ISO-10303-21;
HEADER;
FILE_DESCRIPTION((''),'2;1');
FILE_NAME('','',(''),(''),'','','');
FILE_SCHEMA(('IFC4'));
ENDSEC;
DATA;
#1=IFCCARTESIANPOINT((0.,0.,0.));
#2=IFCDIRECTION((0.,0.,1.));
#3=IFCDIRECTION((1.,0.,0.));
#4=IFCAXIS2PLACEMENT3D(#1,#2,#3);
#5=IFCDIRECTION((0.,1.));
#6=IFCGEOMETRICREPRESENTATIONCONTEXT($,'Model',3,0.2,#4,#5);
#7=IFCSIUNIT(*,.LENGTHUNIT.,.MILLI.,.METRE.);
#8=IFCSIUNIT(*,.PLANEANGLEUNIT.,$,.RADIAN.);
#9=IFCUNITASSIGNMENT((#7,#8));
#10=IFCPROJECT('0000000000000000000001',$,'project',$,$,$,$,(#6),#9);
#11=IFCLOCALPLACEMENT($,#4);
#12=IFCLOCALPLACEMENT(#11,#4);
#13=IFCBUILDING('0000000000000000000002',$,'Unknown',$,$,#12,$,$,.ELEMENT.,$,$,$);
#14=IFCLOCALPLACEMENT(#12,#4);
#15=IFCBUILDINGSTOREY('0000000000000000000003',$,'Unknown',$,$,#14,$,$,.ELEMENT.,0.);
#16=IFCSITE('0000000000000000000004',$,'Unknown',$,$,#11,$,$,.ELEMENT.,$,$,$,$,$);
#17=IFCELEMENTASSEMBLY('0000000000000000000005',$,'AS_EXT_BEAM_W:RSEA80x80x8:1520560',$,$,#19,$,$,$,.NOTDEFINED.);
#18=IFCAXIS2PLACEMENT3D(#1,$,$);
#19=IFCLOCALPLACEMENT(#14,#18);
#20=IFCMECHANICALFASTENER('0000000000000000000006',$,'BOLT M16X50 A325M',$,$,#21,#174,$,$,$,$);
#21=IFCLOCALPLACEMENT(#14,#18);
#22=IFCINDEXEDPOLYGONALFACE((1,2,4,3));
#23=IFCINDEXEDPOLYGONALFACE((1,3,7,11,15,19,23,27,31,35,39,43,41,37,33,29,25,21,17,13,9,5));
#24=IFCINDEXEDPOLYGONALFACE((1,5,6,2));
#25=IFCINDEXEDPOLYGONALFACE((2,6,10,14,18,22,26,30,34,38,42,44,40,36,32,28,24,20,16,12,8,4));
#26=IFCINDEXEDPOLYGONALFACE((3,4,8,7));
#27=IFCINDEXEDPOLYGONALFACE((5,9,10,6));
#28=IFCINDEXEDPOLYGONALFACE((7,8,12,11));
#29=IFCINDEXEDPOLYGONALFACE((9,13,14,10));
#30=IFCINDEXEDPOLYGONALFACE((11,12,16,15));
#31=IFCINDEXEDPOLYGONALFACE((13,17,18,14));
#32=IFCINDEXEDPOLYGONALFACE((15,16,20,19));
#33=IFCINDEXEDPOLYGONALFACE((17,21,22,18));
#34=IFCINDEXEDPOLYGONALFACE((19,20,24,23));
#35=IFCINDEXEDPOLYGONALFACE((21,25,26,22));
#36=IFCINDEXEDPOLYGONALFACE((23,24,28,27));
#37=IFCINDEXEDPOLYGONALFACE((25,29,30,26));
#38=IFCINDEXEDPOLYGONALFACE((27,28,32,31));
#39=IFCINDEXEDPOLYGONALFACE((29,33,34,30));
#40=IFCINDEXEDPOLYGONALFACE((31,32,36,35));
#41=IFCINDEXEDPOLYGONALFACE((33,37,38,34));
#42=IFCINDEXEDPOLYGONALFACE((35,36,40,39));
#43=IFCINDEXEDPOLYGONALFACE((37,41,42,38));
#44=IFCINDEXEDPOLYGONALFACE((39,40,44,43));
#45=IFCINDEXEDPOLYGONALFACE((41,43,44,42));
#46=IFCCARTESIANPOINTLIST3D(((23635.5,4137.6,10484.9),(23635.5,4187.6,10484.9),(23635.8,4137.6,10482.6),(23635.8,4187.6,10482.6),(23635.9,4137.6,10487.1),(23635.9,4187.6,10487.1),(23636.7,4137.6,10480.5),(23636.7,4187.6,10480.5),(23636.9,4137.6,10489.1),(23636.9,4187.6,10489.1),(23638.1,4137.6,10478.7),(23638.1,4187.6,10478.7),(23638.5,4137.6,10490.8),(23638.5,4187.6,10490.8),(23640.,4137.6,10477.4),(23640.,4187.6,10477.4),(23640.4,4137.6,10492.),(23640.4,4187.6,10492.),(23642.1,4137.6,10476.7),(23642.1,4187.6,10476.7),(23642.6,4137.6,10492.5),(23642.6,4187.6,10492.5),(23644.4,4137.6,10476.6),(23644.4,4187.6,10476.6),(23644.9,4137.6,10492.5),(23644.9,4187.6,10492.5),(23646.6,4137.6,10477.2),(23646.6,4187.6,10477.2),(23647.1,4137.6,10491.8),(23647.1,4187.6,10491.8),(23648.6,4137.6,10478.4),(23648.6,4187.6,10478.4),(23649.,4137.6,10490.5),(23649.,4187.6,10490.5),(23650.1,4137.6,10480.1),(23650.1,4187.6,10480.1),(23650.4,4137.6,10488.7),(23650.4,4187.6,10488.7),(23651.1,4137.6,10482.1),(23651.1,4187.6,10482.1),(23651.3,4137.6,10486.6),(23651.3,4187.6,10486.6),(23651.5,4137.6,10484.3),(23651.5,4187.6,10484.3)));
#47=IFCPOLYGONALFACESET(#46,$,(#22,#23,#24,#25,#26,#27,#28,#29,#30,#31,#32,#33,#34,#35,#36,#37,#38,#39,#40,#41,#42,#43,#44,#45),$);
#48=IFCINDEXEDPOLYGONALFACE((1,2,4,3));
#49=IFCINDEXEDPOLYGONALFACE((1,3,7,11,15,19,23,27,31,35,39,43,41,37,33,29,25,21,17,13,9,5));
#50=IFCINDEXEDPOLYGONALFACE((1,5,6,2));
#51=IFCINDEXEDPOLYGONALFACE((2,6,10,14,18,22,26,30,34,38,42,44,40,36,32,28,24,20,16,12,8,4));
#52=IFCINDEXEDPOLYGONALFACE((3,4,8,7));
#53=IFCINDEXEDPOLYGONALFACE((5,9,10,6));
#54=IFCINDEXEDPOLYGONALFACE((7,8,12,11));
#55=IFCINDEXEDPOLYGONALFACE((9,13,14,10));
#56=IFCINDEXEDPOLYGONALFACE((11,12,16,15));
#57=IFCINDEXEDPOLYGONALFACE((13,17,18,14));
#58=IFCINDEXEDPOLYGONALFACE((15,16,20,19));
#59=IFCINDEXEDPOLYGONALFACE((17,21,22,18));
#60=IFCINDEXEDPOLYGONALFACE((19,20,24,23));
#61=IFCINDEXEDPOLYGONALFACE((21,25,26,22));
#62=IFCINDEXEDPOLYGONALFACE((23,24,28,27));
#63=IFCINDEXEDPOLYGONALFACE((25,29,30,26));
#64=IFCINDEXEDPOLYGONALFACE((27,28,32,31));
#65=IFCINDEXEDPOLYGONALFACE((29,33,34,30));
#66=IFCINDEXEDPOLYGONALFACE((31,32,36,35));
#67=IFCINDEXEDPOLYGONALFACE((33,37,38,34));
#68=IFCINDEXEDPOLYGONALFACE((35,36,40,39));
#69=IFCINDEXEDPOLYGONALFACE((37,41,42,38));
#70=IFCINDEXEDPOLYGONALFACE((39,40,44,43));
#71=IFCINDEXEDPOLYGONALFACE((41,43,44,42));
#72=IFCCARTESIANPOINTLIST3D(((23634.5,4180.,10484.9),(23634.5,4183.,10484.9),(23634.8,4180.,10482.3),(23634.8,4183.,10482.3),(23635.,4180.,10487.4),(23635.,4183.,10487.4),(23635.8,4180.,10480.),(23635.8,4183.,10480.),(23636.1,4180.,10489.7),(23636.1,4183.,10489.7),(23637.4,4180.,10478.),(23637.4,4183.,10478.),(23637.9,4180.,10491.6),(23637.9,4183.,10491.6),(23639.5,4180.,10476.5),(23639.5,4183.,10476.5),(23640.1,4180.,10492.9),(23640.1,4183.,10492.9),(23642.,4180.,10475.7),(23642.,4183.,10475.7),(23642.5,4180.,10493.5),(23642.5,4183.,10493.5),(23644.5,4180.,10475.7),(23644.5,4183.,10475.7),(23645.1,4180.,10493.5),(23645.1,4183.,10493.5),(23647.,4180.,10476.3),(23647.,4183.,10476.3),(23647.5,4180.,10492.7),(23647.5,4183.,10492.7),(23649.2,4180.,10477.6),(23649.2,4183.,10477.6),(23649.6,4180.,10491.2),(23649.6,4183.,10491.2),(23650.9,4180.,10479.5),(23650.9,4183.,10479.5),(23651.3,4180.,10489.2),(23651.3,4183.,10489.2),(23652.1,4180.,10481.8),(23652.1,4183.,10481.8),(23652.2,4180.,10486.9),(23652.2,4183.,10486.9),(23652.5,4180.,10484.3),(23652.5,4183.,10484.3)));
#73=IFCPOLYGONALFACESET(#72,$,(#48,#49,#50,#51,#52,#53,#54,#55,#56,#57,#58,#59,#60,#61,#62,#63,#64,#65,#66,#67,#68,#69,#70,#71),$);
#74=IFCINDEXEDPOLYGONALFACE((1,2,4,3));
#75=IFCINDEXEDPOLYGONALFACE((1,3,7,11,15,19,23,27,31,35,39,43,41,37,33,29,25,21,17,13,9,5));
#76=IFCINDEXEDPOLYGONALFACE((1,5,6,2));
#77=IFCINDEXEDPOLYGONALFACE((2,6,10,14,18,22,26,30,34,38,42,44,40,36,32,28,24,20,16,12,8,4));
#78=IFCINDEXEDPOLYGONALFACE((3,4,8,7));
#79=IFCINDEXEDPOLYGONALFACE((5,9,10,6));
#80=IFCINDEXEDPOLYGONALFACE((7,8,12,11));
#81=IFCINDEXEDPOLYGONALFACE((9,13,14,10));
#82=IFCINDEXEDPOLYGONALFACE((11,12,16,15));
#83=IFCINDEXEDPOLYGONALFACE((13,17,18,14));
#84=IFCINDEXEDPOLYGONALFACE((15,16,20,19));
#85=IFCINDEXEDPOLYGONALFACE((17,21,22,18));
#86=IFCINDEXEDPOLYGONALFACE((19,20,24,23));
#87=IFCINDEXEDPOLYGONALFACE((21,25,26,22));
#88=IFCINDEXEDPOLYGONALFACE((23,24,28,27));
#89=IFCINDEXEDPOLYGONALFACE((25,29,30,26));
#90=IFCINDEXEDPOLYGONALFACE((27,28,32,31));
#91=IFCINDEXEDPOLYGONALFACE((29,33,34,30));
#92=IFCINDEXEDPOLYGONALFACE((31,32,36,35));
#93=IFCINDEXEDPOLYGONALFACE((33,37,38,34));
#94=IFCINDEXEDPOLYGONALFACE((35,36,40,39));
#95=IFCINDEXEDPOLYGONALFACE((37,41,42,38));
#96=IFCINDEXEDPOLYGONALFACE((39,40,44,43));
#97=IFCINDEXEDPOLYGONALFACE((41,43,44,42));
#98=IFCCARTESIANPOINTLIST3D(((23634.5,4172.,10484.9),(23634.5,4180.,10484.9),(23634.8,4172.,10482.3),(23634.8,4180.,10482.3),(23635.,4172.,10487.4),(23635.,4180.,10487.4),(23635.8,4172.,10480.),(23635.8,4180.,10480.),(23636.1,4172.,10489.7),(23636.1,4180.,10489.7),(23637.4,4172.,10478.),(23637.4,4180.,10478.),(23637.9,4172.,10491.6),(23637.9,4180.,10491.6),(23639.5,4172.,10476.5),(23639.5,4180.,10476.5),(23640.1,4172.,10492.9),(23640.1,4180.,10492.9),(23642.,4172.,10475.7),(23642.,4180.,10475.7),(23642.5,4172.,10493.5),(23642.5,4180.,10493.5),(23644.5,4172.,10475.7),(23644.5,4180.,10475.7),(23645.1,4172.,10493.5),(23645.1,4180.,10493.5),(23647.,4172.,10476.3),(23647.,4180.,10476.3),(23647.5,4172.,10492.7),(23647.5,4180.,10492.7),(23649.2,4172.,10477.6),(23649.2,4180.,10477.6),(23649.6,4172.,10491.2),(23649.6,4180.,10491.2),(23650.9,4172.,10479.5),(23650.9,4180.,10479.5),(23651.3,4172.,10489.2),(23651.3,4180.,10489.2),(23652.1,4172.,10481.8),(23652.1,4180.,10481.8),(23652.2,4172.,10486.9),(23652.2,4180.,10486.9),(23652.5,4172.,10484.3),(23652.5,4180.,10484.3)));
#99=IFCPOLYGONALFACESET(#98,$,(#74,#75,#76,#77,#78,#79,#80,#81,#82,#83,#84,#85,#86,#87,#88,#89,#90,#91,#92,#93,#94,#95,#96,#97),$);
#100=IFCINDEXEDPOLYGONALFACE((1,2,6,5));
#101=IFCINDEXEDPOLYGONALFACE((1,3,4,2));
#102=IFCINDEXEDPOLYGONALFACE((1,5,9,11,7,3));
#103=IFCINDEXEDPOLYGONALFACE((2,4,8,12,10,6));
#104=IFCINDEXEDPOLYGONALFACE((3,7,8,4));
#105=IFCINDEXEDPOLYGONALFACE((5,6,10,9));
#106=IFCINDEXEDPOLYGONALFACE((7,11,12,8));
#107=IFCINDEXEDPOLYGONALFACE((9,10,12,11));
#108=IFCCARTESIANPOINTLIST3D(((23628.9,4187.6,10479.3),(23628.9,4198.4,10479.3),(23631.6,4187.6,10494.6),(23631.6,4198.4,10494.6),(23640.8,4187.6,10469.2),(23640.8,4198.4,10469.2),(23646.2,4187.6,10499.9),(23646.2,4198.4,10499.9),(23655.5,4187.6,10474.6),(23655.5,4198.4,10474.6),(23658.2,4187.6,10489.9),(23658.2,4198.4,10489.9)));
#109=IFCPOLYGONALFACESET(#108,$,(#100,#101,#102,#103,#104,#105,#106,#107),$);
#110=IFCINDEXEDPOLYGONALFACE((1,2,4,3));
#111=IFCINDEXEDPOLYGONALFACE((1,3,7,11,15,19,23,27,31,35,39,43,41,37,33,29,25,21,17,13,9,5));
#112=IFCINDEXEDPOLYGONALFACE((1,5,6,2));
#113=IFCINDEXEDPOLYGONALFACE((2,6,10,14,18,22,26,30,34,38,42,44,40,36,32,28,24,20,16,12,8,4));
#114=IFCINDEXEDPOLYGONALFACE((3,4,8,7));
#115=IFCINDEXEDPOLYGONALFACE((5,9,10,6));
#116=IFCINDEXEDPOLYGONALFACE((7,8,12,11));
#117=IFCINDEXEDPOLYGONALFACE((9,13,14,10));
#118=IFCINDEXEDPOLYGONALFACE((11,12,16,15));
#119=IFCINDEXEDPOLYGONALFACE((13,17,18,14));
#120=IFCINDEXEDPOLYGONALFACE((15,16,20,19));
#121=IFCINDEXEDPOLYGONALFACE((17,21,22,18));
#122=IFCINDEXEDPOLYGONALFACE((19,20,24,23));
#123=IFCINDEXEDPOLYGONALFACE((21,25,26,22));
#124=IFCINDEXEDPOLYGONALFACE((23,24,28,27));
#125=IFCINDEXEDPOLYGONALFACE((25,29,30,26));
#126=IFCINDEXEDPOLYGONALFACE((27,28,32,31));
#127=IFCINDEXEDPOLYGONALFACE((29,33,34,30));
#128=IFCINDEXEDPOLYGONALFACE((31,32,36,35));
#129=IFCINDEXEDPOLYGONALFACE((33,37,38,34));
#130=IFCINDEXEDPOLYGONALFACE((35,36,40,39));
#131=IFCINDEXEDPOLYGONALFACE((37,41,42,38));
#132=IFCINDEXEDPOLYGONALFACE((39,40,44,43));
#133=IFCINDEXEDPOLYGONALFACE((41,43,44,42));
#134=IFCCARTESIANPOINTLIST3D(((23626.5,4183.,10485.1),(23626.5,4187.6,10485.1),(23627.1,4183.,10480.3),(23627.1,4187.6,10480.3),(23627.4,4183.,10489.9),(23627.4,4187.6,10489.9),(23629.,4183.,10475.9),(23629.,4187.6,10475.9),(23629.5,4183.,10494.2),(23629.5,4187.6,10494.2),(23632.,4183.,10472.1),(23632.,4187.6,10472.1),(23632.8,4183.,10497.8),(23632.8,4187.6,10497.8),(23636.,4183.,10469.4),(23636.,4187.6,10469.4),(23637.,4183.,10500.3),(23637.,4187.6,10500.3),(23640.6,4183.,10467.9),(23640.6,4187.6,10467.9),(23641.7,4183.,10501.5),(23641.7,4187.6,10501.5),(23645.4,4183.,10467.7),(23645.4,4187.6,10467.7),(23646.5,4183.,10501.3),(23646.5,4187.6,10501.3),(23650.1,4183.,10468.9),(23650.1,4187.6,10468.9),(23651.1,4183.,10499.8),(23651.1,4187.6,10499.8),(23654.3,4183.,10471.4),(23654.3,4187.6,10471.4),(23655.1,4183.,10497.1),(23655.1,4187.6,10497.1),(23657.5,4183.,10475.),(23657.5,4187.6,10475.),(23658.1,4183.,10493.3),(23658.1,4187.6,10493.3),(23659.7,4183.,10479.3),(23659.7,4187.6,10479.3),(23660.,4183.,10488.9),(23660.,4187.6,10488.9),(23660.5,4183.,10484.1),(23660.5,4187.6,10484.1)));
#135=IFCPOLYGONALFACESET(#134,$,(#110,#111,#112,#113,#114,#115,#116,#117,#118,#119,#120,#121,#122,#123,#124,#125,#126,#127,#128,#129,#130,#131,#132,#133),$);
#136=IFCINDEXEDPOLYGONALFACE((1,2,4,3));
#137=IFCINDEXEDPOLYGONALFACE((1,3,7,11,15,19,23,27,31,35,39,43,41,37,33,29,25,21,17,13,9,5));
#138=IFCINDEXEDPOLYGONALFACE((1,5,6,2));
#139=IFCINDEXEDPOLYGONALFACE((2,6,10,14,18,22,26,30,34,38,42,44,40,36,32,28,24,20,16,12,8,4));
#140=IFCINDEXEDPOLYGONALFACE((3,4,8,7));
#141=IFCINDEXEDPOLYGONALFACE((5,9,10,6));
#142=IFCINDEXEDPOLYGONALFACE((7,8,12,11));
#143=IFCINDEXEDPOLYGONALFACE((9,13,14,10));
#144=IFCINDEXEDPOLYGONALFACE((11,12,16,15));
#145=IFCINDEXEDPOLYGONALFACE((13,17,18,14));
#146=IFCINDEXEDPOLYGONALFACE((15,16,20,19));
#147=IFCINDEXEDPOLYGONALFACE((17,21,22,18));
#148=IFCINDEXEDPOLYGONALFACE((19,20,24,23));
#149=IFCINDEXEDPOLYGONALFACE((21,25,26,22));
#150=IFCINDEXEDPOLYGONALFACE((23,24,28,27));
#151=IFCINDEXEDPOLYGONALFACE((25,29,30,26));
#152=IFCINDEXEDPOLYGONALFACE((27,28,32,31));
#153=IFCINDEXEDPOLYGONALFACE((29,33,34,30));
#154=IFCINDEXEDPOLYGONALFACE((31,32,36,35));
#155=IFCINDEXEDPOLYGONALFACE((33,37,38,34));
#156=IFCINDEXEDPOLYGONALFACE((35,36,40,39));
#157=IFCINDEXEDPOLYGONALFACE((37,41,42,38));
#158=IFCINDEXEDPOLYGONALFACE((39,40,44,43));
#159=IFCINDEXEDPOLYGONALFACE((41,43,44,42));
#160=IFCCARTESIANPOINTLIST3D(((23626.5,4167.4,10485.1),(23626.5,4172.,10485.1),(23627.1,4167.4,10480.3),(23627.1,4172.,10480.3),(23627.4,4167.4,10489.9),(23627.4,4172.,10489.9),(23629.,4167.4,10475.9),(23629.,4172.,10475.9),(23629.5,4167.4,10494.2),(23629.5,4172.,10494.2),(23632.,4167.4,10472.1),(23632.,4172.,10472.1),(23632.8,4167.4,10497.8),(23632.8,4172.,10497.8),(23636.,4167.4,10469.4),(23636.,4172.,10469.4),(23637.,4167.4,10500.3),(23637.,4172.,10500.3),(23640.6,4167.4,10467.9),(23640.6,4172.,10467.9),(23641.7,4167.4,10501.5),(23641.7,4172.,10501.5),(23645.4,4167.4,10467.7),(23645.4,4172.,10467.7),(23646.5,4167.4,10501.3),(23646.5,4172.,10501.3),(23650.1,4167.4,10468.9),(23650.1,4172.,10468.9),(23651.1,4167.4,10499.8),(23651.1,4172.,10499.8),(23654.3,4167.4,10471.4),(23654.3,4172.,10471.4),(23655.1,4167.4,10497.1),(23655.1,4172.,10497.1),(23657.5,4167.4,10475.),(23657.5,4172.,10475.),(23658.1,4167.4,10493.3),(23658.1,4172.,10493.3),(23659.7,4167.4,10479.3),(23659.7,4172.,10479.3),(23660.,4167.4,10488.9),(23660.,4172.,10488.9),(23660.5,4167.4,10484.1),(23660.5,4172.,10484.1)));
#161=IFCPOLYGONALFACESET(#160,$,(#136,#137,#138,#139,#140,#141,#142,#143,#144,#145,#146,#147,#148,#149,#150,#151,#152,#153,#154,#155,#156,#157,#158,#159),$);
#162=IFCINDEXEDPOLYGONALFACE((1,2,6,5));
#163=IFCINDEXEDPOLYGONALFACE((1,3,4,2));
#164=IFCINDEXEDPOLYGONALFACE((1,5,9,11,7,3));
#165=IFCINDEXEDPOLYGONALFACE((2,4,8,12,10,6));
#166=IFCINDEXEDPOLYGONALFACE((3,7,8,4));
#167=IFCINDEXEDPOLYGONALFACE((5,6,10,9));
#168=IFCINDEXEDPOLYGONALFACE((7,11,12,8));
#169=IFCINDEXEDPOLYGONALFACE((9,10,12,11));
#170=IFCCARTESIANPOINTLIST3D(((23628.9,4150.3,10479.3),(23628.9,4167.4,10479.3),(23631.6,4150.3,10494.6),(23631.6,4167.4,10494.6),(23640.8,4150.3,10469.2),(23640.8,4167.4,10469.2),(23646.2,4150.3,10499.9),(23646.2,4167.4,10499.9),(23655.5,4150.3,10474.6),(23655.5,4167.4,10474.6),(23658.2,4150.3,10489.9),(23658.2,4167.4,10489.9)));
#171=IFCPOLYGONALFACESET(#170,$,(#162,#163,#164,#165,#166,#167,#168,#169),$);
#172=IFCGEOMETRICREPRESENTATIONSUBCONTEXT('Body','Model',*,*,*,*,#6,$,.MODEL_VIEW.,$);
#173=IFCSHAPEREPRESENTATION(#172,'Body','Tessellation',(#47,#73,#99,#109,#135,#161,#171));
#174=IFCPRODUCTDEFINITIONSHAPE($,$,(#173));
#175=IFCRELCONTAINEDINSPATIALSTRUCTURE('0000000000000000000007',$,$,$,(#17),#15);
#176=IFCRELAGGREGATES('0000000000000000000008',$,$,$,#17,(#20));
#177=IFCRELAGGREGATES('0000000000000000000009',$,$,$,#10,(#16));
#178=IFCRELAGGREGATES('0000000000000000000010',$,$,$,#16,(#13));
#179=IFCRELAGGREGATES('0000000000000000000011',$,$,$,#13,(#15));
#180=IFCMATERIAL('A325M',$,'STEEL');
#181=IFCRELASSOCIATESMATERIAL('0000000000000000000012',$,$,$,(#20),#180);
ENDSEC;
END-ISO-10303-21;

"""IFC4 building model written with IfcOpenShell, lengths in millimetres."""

from ifc_helpers import new_model, si_unit, direction, frame, origin_with_axes, place, context, subcontext, project, spatial, line, arc, indexed_curve, outline, extrude, source, transform, mapped, material, element, aggregate, save


model = new_model("IFC4")

# Units and contexts
model_context = context("Model", 3, precision=0.2, world=origin_with_axes(), true_north=direction((0.0, 1.0)))
body_context = subcontext(model_context, "Body", "Model", "MODEL_VIEW")
ifc_project = project(units=[si_unit("LENGTHUNIT", "METRE", prefix="MILLI"), si_unit("PLANEANGLEUNIT", "RADIAN")], contexts=[model_context])

# Site, building, storey
site_placement = place(None, origin_with_axes())
site = spatial("IfcSite", under=ifc_project, at=site_placement, Name="Unknown", CompositionType="ELEMENT")
building_placement = place(site_placement, origin_with_axes())
building = spatial("IfcBuilding", under=site, at=building_placement, Name="Unknown", CompositionType="ELEMENT")
storey_placement = place(building_placement, origin_with_axes())
storey = spatial("IfcBuildingStorey", under=building, at=storey_placement, Name="Unknown", CompositionType="ELEMENT", Elevation=0.0)

# Element assembly
assembly_1_placement = place(storey_placement, frame((23581.1, 4140.0, 10490.5), z_axis=(0.0, -1.0, 0.0), x_axis=(0.984808, 0.0, -0.173648)))
assembly_1 = element("IfcElementAssembly", 1, at=assembly_1_placement, inside=storey, Name="AS_EXT_BEAM_W:RSEA80x80x8:1520560", PredefinedType="NOTDEFINED")

# Mechanical fastener
ifc_material_1 = material(Name="A325M", Category="STEEL")
shared_shape = source(origin_with_axes(), body_context, "Body", "SweptSolid", [
    extrude(outline(indexed_curve([(8.0, 0.0), (0.0, 8.0), (-8.0, 0.0), (0.0, -8.0)], segments=[arc(1, 2, 3), arc(3, 4, 1)])), frame((0.0, 0.0, 15.6), z_axis=(0.0, 0.0, -1.0), x_axis=(0.0, 1.0, 0.0)), (0.0, 0.0, 1.0), 50.0),
    extrude(outline(indexed_curve([(9.0, 0.0), (0.0, 9.0), (-9.0, 0.0), (0.0, -9.0)], segments=[arc(1, 2, 3), arc(3, 4, 1)])), frame((0.0, 0.0, 11.0), z_axis=(0.0, 0.0, -1.0), x_axis=(0.0, 1.0, 0.0)), (0.0, 0.0, 1.0), 3.0),
    extrude(outline(indexed_curve([(9.0, 0.0), (0.0, 9.0), (-9.0, 0.0), (0.0, -9.0)], segments=[arc(1, 2, 3), arc(3, 4, 1)])), frame((0.0, 0.0, 8.0), z_axis=(0.0, 0.0, -1.0), x_axis=(0.0, 1.0, 0.0)), (0.0, 0.0, 1.0), 8.0),
    extrude(outline(indexed_curve([(15.6, 0.0), (7.8, 13.5), (-7.8, 13.5), (-15.6, 0.0), (-7.8, -13.5), (7.8, -13.5)], segments=[line(1, 2, 3, 4, 5, 6, 1)])), frame((0.0, 0.0, 26.4), z_axis=(0.0, 0.0, -1.0), x_axis=(0.0, 1.0, 0.0)), (0.0, 0.0, 1.0), 10.8),
    extrude(outline(indexed_curve([(17.0, 0.0), (0.0, 17.0), (-17.0, 0.0), (0.0, -17.0)], segments=[arc(1, 2, 3), arc(3, 4, 1)])), frame((0.0, 0.0, 15.6), z_axis=(0.0, 0.0, -1.0), x_axis=(0.0, 1.0, 0.0)), (0.0, 0.0, 1.0), 4.6),
    extrude(outline(indexed_curve([(17.0, 0.0), (0.0, 17.0), (-17.0, 0.0), (0.0, -17.0)], segments=[arc(1, 2, 3), arc(3, 4, 1)])), frame((0.0, 0.0, 0.0), z_axis=(0.0, 0.0, -1.0), x_axis=(0.0, 1.0, 0.0)), (0.0, 0.0, 1.0), 4.6),
    extrude(outline(indexed_curve([(15.6, 0.0), (7.8, 13.5), (-7.8, 13.5), (-15.6, 0.0), (-7.8, -13.5), (7.8, -13.5)], segments=[line(1, 2, 3, 4, 5, 6, 1)])), frame((0.0, 0.0, -4.6), z_axis=(0.0, 0.0, -1.0), x_axis=(0.0, 1.0, 0.0)), (0.0, 0.0, 1.0), 17.1),
])
mechanical_fastener_1_placement = place(assembly_1_placement, frame((62.5, 5.0, -32.0), z_axis=(0.0, 0.0, -1.0), x_axis=(1.0, 0.0, 0.0)))
mechanical_fastener_1 = element("IfcMechanicalFastener", 2, at=mechanical_fastener_1_placement, material=ifc_material_1, Name="BOLT M16X50 A325M", context=body_context, shape_type="MappedRepresentation", body=[
    mapped(shared_shape, transform((0.0, 0.0, 0.0))),
])
aggregate(assembly_1, [mechanical_fastener_1])

save(model, "model.ifc")
